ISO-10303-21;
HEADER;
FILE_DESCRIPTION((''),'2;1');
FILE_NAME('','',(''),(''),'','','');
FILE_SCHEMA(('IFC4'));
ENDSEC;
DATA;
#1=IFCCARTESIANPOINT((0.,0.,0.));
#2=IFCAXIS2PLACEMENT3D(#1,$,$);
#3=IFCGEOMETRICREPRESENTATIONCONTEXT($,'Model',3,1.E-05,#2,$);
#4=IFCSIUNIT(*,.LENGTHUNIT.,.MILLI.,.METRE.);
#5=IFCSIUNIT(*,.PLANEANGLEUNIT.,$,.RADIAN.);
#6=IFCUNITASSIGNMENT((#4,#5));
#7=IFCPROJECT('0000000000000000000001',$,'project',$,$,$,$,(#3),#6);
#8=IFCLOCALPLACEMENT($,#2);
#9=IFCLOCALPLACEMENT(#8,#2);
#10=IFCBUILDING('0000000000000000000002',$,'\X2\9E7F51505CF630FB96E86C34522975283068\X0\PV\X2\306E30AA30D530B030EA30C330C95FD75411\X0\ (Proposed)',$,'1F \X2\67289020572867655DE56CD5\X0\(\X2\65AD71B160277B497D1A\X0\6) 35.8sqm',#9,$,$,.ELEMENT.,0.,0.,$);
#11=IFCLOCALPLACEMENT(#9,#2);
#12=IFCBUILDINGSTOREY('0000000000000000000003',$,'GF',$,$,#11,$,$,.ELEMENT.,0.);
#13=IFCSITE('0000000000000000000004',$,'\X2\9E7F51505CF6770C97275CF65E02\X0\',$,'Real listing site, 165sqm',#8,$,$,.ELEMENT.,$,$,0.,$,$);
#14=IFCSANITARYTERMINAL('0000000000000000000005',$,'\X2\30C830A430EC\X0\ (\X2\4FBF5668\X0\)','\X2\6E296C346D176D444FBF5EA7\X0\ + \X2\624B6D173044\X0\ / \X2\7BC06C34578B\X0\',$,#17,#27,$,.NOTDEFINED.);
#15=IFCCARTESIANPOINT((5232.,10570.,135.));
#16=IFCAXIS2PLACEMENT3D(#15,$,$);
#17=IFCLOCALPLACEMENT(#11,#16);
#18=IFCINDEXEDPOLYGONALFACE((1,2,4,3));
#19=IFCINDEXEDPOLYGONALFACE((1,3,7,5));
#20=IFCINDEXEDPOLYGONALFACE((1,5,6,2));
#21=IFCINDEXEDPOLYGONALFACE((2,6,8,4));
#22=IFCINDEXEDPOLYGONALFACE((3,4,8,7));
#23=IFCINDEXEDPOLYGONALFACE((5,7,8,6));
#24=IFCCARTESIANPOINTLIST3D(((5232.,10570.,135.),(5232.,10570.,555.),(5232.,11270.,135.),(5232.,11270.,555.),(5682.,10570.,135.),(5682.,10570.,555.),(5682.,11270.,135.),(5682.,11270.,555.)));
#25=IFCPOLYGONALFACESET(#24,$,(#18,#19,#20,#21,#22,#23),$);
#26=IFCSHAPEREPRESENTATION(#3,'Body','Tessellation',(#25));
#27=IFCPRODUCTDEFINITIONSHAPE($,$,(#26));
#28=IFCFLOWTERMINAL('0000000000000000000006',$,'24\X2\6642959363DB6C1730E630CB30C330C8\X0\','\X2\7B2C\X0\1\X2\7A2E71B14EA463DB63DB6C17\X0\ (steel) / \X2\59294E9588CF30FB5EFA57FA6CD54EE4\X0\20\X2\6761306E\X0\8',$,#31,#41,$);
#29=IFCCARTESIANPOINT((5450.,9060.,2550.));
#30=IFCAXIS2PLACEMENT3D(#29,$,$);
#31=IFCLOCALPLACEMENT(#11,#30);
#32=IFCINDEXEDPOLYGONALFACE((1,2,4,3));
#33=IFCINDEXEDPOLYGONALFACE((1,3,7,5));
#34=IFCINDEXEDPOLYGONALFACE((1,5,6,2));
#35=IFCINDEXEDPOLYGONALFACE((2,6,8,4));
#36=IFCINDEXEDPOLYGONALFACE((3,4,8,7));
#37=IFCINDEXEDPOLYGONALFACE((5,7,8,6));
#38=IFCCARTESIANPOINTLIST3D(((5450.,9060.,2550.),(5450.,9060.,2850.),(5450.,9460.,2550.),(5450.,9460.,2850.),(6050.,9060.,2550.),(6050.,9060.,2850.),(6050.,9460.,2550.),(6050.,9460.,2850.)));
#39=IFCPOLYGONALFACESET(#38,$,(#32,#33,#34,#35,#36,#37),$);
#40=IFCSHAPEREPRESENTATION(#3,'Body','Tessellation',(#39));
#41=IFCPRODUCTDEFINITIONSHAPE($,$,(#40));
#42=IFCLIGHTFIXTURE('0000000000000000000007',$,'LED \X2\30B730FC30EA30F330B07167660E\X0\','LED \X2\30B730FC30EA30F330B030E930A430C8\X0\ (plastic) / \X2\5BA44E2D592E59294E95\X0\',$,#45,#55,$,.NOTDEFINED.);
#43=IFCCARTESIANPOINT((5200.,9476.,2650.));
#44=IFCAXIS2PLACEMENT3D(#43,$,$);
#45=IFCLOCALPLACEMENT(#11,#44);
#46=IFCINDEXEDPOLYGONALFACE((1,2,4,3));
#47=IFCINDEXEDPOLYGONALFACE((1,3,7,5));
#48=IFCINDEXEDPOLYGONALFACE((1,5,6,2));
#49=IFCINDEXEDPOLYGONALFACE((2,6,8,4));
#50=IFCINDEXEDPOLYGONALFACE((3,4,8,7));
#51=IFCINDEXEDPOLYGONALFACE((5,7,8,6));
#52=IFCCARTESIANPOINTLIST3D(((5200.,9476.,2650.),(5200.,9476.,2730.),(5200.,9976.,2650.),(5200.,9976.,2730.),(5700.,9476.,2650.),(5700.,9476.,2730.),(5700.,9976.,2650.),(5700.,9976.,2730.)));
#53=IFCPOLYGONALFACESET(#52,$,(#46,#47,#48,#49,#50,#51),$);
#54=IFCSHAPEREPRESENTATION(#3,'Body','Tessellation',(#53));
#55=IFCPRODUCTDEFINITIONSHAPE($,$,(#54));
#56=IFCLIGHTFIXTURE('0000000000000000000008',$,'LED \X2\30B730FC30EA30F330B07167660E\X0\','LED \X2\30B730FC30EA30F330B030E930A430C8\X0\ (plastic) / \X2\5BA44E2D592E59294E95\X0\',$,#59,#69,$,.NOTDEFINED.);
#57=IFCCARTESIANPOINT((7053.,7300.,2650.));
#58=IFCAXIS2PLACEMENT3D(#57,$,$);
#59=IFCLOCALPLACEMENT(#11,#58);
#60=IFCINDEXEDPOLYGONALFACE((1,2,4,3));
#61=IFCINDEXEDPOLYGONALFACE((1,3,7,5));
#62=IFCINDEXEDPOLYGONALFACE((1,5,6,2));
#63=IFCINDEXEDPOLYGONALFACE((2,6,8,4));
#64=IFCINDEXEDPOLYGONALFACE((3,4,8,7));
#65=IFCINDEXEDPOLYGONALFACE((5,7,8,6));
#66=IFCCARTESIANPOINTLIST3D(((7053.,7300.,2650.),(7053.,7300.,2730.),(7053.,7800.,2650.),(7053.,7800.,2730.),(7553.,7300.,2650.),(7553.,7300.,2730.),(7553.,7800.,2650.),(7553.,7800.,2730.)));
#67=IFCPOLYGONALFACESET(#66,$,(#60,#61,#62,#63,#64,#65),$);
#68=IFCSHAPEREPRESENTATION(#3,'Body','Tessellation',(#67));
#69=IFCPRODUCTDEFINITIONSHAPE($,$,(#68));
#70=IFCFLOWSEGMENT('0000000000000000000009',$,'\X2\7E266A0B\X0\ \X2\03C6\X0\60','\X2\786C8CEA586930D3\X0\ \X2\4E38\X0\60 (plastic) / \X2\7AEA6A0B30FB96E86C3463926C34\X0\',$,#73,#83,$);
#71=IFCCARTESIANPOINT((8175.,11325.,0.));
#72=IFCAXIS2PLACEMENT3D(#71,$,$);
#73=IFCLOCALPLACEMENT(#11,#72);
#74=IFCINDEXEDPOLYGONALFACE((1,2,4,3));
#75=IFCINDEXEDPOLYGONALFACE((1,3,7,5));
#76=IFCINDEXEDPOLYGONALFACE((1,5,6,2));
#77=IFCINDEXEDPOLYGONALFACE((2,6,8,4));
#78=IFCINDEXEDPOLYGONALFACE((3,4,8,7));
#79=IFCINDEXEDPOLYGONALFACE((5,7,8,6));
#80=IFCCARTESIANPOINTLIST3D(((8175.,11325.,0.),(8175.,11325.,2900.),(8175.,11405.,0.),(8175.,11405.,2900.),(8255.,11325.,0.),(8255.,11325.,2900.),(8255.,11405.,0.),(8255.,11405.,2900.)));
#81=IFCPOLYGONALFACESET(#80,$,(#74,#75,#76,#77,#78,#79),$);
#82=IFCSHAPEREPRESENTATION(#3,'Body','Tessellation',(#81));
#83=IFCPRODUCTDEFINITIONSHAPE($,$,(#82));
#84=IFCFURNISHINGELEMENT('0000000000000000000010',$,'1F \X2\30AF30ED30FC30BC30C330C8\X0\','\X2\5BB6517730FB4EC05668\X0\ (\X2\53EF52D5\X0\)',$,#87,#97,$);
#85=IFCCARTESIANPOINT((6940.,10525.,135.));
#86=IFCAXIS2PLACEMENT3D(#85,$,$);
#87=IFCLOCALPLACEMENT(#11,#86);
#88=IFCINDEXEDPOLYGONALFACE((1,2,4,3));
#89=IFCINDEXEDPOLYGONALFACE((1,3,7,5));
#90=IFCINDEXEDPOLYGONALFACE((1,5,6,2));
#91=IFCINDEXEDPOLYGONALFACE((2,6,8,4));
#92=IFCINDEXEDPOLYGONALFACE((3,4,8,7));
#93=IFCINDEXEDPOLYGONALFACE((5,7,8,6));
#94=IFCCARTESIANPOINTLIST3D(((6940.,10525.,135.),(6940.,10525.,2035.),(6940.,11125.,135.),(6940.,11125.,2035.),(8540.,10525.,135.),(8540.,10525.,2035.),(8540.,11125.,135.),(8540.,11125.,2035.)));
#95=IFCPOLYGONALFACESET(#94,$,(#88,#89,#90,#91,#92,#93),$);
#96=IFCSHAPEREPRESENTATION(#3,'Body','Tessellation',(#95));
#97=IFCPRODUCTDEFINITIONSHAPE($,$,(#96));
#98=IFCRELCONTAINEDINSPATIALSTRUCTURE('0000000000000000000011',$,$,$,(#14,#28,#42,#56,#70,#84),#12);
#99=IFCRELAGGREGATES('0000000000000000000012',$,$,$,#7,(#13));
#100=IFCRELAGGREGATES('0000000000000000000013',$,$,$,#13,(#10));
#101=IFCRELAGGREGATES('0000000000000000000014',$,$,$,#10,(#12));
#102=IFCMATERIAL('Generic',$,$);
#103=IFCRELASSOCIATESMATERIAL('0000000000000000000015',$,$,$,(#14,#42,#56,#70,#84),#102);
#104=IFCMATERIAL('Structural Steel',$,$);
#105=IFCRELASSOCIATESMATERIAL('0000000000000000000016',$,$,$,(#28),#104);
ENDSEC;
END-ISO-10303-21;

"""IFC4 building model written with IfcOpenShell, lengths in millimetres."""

from ifc_helpers import new_model, si_unit, frame, frame_2d, origin, place, context, project, spatial, rectangle, extrude, material, element, save


model = new_model("IFC4")

# Units and contexts
model_context = context("Model", 3, precision=1e-05, world=origin())
ifc_project = project(units=[si_unit("LENGTHUNIT", "METRE", prefix="MILLI"), si_unit("PLANEANGLEUNIT", "RADIAN")], contexts=[model_context])

# Site, building, storey
site_placement = place(None, origin())
site = spatial("IfcSite", under=ifc_project, at=site_placement, Name="鹿児島県霧島市", ObjectType="Real listing site, 165sqm", CompositionType="ELEMENT", RefElevation=0.0)
building_placement = place(site_placement, origin())
building = spatial("IfcBuilding", under=site, at=building_placement, Name="鹿児島・雨水利用とPVのオフグリッド志向 (Proposed)", ObjectType="1F 木造在来工法(断熱性等級6) 35.8sqm", CompositionType="ELEMENT", ElevationOfRefHeight=0.0, ElevationOfTerrain=0.0)
storey_placement = place(building_placement, origin())
storey = spatial("IfcBuildingStorey", under=building, at=storey_placement, Name="GF", CompositionType="ELEMENT", Elevation=0.0)

# Shared definitions
ifc_material_1 = material(Name="Generic")

# Sanitary terminal
sanitary_terminal_1_placement = place(storey_placement, frame((5232.0, 10570.0, 135.0)))
element("IfcSanitaryTerminal", 1, at=sanitary_terminal_1_placement, inside=storey, material=ifc_material_1, Name="トイレ (便器)", Description="温水洗浄便座 + 手洗い / 節水型", PredefinedType="NOTDEFINED", context=model_context, shape_type="SweptSolid", body=[
    extrude(rectangle(XDim=450.0, YDim=700.0, at=frame_2d((225.0, 350.0))), frame((5232.0, 10570.0, 135.0)), (0.0, 0.0, 1.0), 420.0),
])

# Flow terminal
ifc_material_2 = material(Name="Structural Steel")
flow_terminal_placement = place(storey_placement, frame((5450.0, 9060.0, 2550.0)))
element("IfcFlowTerminal", 2, at=flow_terminal_placement, inside=storey, material=ifc_material_2, Name="24時間換気ユニット", Description="第1種熱交換換気 (steel) / 天井裏・建基法令20条の8", context=model_context, shape_type="SweptSolid", body=[
    extrude(rectangle(XDim=600.0, YDim=400.0, at=frame_2d((300.0, 200.0))), frame((5450.0, 9060.0, 2550.0)), (0.0, 0.0, 1.0), 300.0),
])

# Light fixtures
light_fixture_1_placement = place(storey_placement, frame((5200.0, 9476.0, 2650.0)))
element("IfcLightFixture", 3, at=light_fixture_1_placement, inside=storey, material=ifc_material_1, Name="LED シーリング照明", Description="LED シーリングライト (plastic) / 室中央天井", PredefinedType="NOTDEFINED", context=model_context, shape_type="SweptSolid", body=[
    extrude(rectangle(XDim=500.0, YDim=500.0, at=frame_2d((250.0, 250.0))), frame((5200.0, 9476.0, 2650.0)), (0.0, 0.0, 1.0), 80.0),
])
light_fixture_2_placement = place(storey_placement, frame((7053.0, 7300.0, 2650.0)))
element("IfcLightFixture", 4, at=light_fixture_2_placement, inside=storey, material=ifc_material_1, Name="LED シーリング照明", Description="LED シーリングライト (plastic) / 室中央天井", PredefinedType="NOTDEFINED", context=model_context, shape_type="SweptSolid", body=[
    extrude(rectangle(XDim=500.0, YDim=500.0, at=frame_2d((250.0, 250.0))), frame((7053.0, 7300.0, 2650.0)), (0.0, 0.0, 1.0), 80.0),
])

# Flow segment
flow_segment_placement = place(storey_placement, frame((8175.0, 11325.0, 0.0)))
element("IfcFlowSegment", 5, at=flow_segment_placement, inside=storey, material=ifc_material_1, Name="縦樋 φ60", Description="硬質塩ビ 丸60 (plastic) / 竪樋・雨水排水", context=model_context, shape_type="SweptSolid", body=[
    extrude(rectangle(XDim=80.0, YDim=80.0, at=frame_2d((40.0, 40.0))), frame((8175.0, 11325.0, 0.0)), (0.0, 0.0, 1.0), 2900.0),
])

# Furnishing element
furnishing_placement = place(storey_placement, frame((6940.0, 10525.0, 135.0)))
element("IfcFurnishingElement", 6, at=furnishing_placement, inside=storey, material=ifc_material_1, Name="1F クローゼット", Description="家具・什器 (可動)", context=model_context, shape_type="SweptSolid", body=[
    extrude(rectangle(XDim=1600.0, YDim=600.0, at=frame_2d((800.0, 300.0))), frame((6940.0, 10525.0, 135.0)), (0.0, 0.0, 1.0), 1900.0),
])

save(model, "model.ifc")
